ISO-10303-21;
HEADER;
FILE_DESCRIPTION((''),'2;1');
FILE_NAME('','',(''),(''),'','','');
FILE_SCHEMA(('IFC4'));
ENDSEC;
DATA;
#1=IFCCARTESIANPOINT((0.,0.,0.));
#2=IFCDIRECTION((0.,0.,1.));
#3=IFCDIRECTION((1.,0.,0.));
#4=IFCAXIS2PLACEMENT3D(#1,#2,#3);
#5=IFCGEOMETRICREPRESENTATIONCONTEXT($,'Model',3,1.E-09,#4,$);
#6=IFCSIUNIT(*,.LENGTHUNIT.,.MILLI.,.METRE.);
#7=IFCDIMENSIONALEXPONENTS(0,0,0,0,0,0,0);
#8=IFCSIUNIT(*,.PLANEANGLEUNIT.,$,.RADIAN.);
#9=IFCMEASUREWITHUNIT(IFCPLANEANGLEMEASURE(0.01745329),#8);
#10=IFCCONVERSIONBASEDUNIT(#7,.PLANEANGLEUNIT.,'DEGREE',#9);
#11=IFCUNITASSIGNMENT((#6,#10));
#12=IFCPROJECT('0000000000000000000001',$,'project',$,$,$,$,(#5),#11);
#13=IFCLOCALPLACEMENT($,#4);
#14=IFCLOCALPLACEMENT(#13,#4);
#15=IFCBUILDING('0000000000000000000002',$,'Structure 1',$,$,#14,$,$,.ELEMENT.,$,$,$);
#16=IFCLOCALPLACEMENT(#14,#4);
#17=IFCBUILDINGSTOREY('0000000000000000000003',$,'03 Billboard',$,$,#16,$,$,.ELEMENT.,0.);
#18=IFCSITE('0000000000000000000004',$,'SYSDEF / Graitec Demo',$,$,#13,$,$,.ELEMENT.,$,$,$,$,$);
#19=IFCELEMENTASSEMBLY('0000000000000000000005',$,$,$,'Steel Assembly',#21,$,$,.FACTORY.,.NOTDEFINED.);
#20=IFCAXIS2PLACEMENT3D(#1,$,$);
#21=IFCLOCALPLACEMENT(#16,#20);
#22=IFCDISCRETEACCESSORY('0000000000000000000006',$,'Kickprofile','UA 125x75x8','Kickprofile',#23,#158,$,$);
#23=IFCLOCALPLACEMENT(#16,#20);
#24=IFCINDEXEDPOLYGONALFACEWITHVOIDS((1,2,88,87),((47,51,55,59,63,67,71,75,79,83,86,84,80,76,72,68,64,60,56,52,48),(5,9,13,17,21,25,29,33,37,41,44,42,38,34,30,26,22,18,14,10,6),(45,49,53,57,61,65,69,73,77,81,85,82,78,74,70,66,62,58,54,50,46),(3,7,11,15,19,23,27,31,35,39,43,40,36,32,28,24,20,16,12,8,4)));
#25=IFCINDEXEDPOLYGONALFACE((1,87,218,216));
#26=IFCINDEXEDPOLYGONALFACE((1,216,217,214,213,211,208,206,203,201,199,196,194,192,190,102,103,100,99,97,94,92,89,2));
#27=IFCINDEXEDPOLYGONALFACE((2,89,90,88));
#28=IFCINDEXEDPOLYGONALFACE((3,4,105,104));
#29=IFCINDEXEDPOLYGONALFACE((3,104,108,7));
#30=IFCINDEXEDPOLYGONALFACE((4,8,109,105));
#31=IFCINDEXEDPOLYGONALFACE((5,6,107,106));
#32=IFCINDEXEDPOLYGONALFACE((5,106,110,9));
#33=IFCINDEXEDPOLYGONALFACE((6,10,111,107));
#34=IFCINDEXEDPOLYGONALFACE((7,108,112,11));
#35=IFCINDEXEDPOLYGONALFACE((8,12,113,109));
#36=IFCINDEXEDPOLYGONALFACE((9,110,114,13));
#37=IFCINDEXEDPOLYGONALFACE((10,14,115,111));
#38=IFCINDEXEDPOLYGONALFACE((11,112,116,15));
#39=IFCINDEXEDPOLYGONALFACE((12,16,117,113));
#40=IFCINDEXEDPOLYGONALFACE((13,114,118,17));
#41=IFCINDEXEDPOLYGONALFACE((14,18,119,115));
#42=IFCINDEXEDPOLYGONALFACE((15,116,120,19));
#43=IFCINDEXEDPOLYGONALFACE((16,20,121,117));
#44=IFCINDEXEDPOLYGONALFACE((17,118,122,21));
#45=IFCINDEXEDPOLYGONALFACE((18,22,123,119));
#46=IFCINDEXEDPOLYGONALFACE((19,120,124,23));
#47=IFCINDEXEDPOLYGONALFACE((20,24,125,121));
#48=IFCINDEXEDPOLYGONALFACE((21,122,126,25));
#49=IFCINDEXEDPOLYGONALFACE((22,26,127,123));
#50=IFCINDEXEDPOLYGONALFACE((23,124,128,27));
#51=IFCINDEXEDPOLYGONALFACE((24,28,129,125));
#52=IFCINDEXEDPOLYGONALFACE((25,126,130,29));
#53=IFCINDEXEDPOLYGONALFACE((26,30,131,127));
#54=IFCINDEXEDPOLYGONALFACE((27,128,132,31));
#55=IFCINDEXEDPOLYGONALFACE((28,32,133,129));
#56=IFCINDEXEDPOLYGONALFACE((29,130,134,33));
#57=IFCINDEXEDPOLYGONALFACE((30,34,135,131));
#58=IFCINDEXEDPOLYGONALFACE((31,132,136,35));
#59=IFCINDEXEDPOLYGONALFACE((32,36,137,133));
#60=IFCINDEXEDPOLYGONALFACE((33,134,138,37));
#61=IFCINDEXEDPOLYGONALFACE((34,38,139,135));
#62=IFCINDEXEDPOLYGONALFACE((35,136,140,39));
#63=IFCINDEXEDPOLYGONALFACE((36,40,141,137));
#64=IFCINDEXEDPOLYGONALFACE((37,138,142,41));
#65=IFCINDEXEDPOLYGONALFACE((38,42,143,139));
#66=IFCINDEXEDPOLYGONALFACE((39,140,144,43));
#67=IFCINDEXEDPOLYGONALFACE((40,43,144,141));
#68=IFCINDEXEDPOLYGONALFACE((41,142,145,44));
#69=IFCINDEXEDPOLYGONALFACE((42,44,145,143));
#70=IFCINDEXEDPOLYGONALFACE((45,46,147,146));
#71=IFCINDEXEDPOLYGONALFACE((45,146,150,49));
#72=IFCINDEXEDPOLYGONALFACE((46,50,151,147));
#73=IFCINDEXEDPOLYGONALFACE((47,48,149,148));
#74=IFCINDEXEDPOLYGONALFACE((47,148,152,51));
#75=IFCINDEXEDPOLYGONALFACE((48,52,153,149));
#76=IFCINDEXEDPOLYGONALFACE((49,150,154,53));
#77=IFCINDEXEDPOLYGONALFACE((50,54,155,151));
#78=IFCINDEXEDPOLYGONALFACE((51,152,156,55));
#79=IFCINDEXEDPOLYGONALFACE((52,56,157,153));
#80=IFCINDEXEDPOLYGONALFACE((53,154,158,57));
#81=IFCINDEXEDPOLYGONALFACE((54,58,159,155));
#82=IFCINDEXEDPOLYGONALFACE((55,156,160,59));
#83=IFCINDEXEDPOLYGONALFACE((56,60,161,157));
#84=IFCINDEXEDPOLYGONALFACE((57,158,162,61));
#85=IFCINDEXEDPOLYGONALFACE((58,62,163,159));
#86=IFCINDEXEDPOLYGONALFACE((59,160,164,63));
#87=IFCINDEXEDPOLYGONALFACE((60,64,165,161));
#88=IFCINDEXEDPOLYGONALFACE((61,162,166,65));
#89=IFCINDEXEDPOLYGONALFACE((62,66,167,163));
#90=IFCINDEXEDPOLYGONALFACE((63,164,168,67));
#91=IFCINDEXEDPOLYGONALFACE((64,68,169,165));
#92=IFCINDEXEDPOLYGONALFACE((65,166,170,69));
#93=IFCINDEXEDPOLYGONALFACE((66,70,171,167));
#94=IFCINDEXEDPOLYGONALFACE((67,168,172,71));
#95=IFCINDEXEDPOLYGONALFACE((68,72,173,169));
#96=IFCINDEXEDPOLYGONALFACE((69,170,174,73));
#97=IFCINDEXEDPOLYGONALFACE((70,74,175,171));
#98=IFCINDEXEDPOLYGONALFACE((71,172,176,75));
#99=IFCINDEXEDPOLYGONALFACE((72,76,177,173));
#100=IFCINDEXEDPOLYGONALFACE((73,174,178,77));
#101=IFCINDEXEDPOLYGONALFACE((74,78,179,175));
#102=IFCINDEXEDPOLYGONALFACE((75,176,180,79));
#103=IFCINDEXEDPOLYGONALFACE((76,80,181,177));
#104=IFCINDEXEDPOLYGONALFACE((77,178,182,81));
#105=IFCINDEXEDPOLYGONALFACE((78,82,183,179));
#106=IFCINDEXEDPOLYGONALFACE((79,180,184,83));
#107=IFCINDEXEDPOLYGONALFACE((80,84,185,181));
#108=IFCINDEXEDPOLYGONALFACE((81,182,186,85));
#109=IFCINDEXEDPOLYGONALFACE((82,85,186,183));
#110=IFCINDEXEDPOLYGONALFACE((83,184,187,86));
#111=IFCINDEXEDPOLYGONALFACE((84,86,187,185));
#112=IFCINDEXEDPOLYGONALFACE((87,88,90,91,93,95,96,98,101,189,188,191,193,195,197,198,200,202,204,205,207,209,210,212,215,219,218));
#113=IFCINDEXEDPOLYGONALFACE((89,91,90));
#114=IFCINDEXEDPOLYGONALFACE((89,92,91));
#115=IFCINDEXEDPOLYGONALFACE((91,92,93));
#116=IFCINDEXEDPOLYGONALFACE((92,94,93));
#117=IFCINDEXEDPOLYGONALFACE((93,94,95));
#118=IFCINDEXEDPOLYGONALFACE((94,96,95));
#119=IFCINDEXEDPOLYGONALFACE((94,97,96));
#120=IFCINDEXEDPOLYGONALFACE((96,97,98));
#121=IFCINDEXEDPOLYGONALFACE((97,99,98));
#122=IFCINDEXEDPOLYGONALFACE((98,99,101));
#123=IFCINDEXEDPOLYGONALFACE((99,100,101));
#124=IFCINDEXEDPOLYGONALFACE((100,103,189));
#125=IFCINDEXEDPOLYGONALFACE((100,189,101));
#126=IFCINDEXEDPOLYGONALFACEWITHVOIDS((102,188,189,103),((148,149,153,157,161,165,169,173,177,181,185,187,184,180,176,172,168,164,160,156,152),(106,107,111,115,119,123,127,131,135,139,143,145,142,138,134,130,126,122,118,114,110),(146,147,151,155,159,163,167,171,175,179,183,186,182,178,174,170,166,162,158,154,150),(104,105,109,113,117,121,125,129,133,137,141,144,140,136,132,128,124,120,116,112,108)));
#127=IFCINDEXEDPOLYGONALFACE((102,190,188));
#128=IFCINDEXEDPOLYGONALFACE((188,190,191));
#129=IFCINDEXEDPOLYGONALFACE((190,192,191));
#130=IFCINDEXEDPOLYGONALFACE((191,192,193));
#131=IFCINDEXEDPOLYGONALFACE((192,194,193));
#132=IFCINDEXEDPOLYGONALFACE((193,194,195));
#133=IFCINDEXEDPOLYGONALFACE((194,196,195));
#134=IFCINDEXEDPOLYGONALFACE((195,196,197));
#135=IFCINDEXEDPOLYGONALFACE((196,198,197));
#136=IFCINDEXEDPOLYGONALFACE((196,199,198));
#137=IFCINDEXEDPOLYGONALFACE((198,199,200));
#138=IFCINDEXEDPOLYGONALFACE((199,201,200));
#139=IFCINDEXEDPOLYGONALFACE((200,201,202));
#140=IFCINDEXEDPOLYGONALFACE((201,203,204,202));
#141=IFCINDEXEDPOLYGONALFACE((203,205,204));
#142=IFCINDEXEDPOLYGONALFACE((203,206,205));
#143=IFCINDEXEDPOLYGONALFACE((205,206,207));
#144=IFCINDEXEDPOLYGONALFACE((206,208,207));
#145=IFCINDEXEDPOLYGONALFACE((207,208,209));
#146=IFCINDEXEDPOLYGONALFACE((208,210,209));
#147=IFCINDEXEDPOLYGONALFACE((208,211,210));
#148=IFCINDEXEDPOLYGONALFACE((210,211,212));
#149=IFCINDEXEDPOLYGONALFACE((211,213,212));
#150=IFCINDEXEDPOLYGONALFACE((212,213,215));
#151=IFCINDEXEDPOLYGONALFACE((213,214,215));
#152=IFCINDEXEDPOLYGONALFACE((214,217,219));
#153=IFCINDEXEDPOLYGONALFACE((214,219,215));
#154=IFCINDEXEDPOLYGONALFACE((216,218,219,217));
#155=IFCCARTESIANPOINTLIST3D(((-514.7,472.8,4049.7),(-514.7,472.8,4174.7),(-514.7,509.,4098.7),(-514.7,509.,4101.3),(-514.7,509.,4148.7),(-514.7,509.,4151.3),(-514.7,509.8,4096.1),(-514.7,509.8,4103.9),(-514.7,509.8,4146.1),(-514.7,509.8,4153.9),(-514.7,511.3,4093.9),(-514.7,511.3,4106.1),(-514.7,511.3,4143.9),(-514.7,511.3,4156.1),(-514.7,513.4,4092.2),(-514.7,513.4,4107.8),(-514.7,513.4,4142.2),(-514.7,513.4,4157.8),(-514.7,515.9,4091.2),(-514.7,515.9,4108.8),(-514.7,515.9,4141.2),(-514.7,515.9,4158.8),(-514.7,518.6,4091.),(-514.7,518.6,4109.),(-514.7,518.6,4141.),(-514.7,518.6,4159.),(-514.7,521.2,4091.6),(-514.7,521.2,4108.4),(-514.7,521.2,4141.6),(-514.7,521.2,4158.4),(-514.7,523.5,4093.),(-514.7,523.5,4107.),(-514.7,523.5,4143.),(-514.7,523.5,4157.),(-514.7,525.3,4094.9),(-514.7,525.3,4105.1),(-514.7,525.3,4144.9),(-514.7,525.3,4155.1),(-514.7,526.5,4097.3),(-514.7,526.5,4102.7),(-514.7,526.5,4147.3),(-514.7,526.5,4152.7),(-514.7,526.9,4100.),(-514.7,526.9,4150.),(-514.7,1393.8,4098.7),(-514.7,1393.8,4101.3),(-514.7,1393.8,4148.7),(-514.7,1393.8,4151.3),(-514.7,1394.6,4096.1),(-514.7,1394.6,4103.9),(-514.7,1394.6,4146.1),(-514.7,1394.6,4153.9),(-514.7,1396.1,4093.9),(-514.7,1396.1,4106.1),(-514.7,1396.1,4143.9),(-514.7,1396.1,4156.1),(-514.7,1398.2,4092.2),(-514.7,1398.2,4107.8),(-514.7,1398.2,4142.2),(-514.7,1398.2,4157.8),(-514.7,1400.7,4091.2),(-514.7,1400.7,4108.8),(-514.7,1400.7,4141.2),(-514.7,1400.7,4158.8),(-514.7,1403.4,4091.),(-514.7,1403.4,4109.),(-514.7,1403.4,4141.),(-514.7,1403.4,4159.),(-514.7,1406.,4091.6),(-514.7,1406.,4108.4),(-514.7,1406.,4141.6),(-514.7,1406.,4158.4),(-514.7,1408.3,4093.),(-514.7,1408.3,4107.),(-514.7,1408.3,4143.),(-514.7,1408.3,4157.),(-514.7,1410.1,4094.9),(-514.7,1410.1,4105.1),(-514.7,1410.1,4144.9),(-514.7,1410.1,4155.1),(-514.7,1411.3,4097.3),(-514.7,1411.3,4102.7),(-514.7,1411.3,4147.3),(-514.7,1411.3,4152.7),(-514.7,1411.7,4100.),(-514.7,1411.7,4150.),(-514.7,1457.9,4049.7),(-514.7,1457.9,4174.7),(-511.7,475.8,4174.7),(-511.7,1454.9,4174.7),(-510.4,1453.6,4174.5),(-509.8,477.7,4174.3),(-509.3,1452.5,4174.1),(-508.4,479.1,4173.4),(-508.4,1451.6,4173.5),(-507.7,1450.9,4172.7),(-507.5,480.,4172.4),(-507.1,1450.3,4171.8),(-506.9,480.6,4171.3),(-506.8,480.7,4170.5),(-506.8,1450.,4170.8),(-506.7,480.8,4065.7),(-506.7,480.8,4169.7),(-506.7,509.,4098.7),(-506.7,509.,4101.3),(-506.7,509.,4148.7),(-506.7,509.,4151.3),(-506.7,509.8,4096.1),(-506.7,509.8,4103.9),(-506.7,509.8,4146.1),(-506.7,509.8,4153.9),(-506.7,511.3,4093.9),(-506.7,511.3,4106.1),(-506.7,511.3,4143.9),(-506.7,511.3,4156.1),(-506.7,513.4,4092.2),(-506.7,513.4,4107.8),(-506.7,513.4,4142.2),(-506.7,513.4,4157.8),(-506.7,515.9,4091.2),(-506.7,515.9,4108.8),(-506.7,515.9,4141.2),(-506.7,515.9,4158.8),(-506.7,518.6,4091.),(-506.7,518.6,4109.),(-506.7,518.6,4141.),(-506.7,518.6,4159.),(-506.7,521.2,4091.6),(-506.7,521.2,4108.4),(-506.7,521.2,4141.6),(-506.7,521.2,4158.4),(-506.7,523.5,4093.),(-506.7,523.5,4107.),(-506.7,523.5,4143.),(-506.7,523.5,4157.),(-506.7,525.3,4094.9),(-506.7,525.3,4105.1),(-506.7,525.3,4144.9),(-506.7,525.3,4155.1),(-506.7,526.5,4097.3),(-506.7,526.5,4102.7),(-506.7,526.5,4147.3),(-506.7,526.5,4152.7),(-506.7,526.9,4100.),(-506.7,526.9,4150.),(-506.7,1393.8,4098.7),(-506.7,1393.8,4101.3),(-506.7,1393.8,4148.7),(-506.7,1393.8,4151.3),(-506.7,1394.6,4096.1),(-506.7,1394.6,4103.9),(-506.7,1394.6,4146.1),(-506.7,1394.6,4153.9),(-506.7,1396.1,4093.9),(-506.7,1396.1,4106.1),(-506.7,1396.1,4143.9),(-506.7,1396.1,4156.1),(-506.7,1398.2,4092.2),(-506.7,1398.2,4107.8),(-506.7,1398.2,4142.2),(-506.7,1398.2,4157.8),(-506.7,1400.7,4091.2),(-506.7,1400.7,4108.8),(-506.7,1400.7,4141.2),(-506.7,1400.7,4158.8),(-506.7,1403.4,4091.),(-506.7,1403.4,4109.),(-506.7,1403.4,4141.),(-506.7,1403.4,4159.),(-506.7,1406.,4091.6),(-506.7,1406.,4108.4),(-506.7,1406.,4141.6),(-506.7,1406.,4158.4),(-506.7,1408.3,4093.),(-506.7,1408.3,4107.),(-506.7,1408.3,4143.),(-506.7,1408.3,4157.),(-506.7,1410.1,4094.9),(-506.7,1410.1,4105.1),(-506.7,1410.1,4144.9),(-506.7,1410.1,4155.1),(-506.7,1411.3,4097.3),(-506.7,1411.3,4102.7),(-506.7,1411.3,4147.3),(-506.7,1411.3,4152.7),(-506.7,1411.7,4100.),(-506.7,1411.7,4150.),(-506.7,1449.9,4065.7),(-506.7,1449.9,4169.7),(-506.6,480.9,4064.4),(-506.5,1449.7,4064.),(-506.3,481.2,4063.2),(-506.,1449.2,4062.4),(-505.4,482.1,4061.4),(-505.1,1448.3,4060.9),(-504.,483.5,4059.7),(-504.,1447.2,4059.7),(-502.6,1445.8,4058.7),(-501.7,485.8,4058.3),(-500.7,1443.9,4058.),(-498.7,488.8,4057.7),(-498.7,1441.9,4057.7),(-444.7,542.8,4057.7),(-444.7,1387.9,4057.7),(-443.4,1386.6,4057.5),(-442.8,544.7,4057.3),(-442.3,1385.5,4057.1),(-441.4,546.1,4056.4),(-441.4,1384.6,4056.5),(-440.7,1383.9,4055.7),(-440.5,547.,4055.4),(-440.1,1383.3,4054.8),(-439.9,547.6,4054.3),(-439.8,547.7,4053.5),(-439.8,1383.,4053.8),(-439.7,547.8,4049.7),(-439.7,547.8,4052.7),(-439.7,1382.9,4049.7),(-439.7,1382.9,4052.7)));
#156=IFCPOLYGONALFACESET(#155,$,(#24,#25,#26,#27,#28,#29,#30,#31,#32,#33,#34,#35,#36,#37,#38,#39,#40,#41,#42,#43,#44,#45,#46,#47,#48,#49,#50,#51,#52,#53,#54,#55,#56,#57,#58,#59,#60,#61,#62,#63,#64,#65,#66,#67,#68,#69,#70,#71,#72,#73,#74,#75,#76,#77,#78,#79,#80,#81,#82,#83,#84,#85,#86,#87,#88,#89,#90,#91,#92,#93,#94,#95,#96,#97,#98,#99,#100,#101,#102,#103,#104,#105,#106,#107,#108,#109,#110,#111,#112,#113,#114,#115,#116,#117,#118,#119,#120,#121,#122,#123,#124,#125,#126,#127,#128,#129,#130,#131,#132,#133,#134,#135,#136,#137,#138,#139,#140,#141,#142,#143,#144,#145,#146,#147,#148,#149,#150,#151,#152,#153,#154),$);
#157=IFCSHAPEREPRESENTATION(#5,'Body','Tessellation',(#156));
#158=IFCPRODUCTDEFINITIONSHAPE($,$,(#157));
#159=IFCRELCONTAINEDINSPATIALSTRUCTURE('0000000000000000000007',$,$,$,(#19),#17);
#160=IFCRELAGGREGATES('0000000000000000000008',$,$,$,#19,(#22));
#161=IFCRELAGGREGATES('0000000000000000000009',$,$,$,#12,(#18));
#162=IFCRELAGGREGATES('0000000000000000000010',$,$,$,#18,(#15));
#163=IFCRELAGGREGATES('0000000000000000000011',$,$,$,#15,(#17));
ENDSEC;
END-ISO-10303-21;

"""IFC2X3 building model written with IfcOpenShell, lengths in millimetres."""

from ifc_helpers import new_model, entity, si_unit, converted_unit, frame, frame_2d, origin, origin_with_axes, place, context, project, spatial, circle, l_section, extrude, clip, halfspace, element, aggregate, save


model = new_model("IFC2X3")

# Units and contexts
model_context = context("Model", 3, precision=1e-09, world=origin_with_axes())
ifc_project = project(units=[si_unit("LENGTHUNIT", "METRE", prefix="MILLI"), converted_unit("PLANEANGLEUNIT", "DEGREE", entity("IfcPlaneAngleMeasure", 0.01745329), si_unit("PLANEANGLEUNIT", "RADIAN"), dimensions=[0, 0, 0, 0, 0, 0, 0])], contexts=[model_context])

# Site, building, storey
site_placement = place(None, origin_with_axes())
site = spatial("IfcSite", under=ifc_project, at=site_placement, Name="SYSDEF / Graitec Demo", CompositionType="ELEMENT")
building_placement = place(site_placement, origin_with_axes())
building = spatial("IfcBuilding", under=site, at=building_placement, Name="Structure 1", CompositionType="ELEMENT")
storey_placement = place(building_placement, origin_with_axes())
storey = spatial("IfcBuildingStorey", under=building, at=storey_placement, Name="03 Billboard", CompositionType="ELEMENT", Elevation=0.0)

# Element assembly, discrete accessory, openings
assembly_1_placement = place(None, frame((935.5, 1441.4, 4091.5), z_axis=(-1.0, 0.0, 0.0), x_axis=(0.0, -1.0, 0.0)))
assembly_1 = element("IfcElementAssembly", 1, at=assembly_1_placement, inside=storey, ObjectType="Steel Assembly", AssemblyPlace="FACTORY", PredefinedType="NOTDEFINED")
discrete_accessory_1_placement = place(assembly_1_placement, frame((1189.4, 0.0, 1433.7), z_axis=(1.0, 0.0, 0.0), x_axis=(0.0, 0.0, -1.0)))
discrete_accessory_1 = element("IfcDiscreteAccessory", 2, at=discrete_accessory_1_placement, Name="Kickprofile", Description="UA 125x75x8", ObjectType="Kickprofile", context=model_context, shape_type="Clipping", body=[
    clip(clip(extrude(l_section(Depth=125.0, Width=75.0, Thickness=8.0, FilletRadius=8.0, EdgeRadius=5.0, at=frame_2d((21.0, 20.7))), origin(), (0.0, 0.0, -1.0), 1426.6), halfspace(frame((969.8, -4091.5, -219.6), z_axis=(-0.707107, 0.0, 0.707107), x_axis=(0.707107, 0.0, 0.707107)), True)), halfspace(frame((4.4, -4091.5, -241.7), z_axis=(-0.707107, 0.0, -0.707107), x_axis=(-0.707107, 0.0, 0.707107)), True)),
])
opening_1_placement = place(discrete_accessory_1_placement, frame((-17.3, 33.5, -1150.7), z_axis=(1.0, 0.0, 0.0), x_axis=(0.0, 0.0, -1.0)))
element("IfcOpeningElement", 3, at=opening_1_placement, cuts=discrete_accessory_1, ObjectType="Opening", context=model_context, shape_type="SweptSolid", body=[
    extrude(circle(Radius=9.0, at=frame_2d((0.0, 25.0), x_axis=(1.0, 0.0))), origin(), (0.0, 0.0, 1.0), 9.0),
])
opening_2_placement = place(discrete_accessory_1_placement, frame((-17.3, 33.5, -1150.7), z_axis=(1.0, 0.0, 0.0), x_axis=(0.0, 0.0, -1.0)))
element("IfcOpeningElement", 4, at=opening_2_placement, cuts=discrete_accessory_1, ObjectType="Opening", context=model_context, shape_type="SweptSolid", body=[
    extrude(circle(Radius=9.0, at=frame_2d((0.0, -25.0), x_axis=(1.0, 0.0))), origin(), (0.0, 0.0, 1.0), 9.0),
])
opening_3_placement = place(discrete_accessory_1_placement, frame((-17.3, 33.5, -265.9), z_axis=(1.0, 0.0, 0.0), x_axis=(0.0, 0.0, -1.0)))
element("IfcOpeningElement", 5, at=opening_3_placement, cuts=discrete_accessory_1, ObjectType="Opening", context=model_context, shape_type="SweptSolid", body=[
    extrude(circle(Radius=9.0, at=frame_2d((0.0, 25.0), x_axis=(1.0, 0.0))), origin(), (0.0, 0.0, 1.0), 9.0),
])
opening_4_placement = place(discrete_accessory_1_placement, frame((-17.3, 33.5, -265.9), z_axis=(1.0, 0.0, 0.0), x_axis=(0.0, 0.0, -1.0)))
element("IfcOpeningElement", 6, at=opening_4_placement, cuts=discrete_accessory_1, ObjectType="Opening", context=model_context, shape_type="SweptSolid", body=[
    extrude(circle(Radius=9.0, at=frame_2d((0.0, -25.0), x_axis=(1.0, 0.0))), origin(), (0.0, 0.0, 1.0), 9.0),
])
aggregate(assembly_1, [discrete_accessory_1])

save(model, "model.ifc")
